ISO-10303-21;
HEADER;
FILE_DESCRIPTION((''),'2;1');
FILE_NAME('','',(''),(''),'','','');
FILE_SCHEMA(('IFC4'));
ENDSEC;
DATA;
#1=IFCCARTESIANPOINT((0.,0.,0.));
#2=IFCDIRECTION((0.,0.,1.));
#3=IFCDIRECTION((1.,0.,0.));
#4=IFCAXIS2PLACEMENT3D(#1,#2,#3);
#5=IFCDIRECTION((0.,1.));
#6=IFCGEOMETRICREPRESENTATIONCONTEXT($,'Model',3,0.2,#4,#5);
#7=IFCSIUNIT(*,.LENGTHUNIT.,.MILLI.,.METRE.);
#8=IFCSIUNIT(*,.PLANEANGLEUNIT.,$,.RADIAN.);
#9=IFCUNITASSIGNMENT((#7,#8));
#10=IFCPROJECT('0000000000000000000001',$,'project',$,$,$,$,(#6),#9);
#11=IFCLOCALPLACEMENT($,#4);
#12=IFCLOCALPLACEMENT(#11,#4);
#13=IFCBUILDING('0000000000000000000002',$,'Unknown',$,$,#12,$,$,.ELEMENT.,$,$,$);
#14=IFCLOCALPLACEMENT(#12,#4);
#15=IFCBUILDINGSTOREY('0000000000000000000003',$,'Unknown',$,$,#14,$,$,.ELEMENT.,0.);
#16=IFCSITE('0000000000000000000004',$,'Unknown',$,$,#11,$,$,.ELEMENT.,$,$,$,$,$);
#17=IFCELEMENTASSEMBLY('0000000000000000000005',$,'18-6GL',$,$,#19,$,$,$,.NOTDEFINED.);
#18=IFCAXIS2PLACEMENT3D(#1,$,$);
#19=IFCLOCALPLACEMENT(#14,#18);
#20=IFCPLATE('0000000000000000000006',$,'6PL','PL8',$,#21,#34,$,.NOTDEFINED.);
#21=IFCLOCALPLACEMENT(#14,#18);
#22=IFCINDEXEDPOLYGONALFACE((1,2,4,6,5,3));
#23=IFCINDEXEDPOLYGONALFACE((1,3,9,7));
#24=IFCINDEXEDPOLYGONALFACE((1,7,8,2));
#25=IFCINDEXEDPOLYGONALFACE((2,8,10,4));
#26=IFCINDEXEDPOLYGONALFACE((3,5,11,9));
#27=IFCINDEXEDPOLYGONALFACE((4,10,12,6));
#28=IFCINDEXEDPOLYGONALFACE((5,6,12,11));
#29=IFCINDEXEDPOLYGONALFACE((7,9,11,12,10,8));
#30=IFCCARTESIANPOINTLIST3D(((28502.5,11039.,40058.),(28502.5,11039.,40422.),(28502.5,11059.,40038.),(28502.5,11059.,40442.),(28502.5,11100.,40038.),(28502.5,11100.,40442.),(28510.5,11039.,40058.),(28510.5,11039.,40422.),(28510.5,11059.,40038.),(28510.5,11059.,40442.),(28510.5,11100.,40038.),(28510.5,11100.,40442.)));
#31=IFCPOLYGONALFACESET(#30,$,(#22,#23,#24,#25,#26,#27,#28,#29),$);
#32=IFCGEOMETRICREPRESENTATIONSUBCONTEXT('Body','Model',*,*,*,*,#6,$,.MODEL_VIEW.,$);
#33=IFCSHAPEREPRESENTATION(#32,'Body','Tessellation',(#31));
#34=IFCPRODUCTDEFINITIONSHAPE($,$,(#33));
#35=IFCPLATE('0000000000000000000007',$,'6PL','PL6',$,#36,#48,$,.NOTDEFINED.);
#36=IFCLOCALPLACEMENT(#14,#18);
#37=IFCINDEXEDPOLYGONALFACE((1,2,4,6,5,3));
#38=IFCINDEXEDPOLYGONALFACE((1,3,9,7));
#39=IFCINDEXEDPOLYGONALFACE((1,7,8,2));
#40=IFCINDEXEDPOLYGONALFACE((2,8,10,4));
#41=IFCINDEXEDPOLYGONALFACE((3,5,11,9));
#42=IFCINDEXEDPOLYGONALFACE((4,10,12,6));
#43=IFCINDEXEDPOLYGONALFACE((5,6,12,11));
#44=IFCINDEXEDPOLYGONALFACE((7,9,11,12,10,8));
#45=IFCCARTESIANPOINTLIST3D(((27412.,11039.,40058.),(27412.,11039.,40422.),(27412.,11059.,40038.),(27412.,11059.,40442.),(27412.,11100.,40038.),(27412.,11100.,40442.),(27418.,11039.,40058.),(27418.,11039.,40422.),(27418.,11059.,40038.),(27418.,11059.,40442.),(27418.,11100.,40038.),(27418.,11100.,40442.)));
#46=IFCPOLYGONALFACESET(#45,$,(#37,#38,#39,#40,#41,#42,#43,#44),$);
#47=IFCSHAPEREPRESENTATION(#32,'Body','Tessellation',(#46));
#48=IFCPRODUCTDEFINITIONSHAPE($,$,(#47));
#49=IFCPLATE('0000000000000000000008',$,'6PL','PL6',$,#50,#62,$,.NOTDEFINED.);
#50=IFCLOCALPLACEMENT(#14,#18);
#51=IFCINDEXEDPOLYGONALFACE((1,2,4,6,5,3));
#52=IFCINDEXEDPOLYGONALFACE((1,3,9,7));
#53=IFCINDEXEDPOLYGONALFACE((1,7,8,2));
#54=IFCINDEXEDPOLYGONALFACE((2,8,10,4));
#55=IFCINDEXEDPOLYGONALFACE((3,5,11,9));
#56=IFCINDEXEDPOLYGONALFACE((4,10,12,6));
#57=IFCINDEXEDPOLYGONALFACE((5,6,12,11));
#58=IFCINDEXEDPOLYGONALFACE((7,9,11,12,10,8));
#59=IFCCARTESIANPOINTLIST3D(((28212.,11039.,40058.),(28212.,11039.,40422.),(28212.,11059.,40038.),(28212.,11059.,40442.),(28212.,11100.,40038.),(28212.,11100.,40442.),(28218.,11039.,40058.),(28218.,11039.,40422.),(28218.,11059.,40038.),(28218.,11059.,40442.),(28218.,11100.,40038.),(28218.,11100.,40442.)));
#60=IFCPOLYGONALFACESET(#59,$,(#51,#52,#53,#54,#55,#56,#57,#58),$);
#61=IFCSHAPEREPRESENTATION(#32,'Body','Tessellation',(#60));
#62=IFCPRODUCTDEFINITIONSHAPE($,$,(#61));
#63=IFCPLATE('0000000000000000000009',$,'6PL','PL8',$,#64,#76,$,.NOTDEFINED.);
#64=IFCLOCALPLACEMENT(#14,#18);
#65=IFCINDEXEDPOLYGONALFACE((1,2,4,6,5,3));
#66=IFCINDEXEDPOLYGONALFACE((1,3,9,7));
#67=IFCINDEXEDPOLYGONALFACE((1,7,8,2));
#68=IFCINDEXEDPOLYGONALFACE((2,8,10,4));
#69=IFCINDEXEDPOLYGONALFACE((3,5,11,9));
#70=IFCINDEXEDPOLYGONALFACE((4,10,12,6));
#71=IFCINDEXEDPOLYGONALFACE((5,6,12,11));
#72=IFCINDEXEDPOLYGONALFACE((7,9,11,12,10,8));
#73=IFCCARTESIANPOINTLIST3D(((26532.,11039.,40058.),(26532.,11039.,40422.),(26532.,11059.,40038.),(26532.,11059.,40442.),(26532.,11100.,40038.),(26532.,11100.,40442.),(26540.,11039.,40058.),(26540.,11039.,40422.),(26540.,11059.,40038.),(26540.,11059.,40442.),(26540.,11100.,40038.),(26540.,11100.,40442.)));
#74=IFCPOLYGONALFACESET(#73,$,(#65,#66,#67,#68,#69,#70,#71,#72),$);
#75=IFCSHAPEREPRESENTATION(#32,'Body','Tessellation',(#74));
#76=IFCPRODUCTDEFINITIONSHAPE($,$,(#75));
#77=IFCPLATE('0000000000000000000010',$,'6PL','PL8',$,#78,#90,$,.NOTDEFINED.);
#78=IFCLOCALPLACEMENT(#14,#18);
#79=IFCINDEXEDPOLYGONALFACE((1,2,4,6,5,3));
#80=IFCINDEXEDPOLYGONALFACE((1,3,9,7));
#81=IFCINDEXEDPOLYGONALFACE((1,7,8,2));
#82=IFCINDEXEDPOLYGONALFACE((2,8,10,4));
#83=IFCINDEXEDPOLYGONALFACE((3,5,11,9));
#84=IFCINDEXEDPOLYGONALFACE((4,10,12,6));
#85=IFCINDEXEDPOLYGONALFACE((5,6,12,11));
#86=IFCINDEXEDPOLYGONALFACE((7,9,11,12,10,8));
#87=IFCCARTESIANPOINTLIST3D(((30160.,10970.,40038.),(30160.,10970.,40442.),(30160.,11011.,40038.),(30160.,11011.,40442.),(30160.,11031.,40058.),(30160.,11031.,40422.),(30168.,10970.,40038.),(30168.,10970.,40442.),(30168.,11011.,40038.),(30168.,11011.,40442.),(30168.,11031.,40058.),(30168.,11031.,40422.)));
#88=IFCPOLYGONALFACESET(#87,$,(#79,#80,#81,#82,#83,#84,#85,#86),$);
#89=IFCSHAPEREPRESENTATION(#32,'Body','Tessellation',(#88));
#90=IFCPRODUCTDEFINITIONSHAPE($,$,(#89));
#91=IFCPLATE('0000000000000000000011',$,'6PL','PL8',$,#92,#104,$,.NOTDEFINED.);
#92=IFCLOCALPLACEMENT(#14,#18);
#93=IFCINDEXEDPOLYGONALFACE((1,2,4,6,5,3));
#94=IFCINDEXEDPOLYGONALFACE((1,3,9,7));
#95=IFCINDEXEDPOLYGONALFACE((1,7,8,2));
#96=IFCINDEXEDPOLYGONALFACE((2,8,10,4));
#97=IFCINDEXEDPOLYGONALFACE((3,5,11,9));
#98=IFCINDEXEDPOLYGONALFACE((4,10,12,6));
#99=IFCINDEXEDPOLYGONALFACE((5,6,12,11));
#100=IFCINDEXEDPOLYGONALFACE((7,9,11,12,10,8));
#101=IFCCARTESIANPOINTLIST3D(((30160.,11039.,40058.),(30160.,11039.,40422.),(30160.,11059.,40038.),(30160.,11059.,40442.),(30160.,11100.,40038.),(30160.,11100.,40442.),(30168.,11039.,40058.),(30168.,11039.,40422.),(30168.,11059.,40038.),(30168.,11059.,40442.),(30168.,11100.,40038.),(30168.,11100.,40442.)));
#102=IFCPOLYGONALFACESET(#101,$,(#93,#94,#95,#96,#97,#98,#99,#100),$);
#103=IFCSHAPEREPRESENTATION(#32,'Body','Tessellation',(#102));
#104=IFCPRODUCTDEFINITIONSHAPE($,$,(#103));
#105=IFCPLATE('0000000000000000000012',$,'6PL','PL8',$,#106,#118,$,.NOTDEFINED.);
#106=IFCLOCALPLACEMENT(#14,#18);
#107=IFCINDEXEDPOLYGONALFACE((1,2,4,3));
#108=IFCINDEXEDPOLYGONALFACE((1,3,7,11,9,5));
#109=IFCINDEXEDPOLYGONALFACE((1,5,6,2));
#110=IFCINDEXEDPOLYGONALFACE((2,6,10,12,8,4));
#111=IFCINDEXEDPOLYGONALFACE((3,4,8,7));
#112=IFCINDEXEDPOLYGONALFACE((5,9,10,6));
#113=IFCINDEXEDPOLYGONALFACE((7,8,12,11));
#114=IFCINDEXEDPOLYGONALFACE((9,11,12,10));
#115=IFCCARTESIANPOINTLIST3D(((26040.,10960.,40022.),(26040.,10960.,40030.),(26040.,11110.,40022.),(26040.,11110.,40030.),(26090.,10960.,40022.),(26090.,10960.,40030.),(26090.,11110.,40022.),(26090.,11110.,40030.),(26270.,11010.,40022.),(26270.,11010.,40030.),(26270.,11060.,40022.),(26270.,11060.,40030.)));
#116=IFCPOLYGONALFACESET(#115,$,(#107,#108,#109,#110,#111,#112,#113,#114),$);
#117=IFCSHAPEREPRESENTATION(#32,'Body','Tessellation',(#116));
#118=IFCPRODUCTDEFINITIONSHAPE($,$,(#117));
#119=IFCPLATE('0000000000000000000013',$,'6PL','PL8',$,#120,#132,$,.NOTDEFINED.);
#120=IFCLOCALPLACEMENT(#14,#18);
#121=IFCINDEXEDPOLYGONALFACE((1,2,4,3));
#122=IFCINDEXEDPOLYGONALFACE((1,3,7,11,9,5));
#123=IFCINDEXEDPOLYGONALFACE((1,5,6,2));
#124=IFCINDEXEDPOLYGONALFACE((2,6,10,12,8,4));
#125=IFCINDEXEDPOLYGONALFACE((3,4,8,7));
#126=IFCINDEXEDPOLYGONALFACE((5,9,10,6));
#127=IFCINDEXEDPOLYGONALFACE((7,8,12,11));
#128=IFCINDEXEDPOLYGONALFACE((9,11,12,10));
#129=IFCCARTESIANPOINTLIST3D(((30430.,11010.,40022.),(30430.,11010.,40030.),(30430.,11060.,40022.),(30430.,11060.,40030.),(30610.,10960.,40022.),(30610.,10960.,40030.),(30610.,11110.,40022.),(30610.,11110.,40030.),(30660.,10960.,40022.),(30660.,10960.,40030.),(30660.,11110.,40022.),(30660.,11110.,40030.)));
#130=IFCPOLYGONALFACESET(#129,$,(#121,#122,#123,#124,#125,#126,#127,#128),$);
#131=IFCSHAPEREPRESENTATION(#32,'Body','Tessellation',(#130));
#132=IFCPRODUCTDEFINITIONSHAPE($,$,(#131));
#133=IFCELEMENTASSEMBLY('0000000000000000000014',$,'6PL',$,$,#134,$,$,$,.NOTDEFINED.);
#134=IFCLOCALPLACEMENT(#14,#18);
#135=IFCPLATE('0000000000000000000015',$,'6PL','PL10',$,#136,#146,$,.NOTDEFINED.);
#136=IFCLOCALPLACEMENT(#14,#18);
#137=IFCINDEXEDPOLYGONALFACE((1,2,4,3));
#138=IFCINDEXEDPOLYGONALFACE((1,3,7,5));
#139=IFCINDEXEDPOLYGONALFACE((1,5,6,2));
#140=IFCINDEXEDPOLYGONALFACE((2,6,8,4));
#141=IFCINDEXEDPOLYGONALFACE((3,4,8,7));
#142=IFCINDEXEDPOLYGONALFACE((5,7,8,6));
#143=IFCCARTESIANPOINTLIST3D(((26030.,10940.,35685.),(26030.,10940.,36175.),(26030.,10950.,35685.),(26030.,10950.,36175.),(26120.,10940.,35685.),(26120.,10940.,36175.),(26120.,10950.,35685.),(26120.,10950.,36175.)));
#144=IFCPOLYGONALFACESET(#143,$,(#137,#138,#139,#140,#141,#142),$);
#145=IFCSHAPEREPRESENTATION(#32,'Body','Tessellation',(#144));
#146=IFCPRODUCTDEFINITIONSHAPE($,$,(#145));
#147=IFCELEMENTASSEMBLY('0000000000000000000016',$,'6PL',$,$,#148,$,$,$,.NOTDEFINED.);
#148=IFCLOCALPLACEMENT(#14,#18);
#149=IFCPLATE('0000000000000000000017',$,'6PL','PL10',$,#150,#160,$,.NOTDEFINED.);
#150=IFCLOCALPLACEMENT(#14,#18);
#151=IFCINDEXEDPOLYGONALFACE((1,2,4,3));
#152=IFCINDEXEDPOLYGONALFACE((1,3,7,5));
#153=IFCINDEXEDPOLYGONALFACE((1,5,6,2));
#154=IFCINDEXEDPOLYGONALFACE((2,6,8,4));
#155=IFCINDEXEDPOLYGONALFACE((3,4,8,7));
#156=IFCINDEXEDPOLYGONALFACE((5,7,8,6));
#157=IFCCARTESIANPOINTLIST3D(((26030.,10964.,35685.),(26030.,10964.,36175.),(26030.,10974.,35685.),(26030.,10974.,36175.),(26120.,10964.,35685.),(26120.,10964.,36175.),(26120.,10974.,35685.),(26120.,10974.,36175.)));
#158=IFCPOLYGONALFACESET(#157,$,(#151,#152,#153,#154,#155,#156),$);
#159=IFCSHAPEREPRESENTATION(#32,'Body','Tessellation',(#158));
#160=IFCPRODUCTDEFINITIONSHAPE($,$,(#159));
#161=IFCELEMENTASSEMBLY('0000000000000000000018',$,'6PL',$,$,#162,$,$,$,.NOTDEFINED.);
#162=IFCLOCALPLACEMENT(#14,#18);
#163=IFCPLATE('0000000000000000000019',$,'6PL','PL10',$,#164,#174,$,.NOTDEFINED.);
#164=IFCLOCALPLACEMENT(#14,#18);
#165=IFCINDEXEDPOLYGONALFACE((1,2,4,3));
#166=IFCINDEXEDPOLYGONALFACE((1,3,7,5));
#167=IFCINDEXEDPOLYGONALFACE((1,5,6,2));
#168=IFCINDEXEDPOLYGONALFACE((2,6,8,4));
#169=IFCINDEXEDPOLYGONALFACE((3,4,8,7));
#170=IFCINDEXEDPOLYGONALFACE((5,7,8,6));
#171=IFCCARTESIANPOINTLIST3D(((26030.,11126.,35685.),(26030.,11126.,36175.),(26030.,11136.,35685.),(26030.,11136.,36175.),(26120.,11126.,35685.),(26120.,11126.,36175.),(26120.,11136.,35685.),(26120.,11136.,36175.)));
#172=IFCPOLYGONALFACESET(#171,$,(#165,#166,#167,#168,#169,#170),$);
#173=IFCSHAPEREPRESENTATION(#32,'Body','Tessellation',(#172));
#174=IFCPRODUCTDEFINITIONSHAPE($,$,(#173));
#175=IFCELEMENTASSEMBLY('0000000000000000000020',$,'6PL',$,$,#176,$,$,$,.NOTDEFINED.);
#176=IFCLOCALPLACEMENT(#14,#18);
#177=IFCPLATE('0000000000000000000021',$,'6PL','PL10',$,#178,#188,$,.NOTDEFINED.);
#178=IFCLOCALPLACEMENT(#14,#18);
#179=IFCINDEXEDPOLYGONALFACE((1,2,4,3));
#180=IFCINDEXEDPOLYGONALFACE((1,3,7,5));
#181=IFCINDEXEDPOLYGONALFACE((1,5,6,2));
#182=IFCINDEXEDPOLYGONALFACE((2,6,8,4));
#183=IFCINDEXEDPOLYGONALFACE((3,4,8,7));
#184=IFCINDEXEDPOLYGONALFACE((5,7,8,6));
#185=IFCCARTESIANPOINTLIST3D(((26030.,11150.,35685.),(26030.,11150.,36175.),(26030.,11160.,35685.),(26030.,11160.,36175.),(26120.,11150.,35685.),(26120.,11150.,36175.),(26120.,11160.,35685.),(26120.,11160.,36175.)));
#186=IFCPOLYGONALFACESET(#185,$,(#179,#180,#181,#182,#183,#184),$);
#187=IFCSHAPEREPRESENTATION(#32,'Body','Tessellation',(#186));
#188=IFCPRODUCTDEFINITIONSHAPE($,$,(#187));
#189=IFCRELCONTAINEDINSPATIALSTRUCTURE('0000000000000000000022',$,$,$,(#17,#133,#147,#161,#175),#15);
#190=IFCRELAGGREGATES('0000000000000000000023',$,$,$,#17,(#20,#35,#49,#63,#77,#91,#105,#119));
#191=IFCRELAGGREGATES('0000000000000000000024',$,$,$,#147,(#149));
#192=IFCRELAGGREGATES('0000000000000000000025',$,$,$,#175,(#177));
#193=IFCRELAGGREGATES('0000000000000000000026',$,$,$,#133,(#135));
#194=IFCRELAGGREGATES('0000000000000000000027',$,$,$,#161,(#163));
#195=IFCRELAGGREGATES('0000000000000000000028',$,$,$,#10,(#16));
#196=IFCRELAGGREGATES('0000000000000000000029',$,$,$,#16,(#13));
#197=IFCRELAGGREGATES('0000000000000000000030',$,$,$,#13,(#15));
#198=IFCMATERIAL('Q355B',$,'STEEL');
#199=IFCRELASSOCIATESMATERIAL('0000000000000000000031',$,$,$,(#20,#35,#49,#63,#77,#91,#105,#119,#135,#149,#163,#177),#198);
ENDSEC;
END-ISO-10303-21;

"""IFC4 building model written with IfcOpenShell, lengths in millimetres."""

from ifc_helpers import new_model, si_unit, direction, frame, origin_with_axes, place, context, subcontext, project, spatial, line, indexed_curve, outline, extrude, material, element, aggregate, save


model = new_model("IFC4")

# Units and contexts
model_context = context("Model", 3, precision=0.2, world=origin_with_axes(), true_north=direction((0.0, 1.0)))
body_context = subcontext(model_context, "Body", "Model", "MODEL_VIEW")
ifc_project = project(units=[si_unit("LENGTHUNIT", "METRE", prefix="MILLI"), si_unit("PLANEANGLEUNIT", "RADIAN")], contexts=[model_context])

# Site, building, storey
site_placement = place(None, origin_with_axes())
site = spatial("IfcSite", under=ifc_project, at=site_placement, Name="Unknown", CompositionType="ELEMENT")
building_placement = place(site_placement, origin_with_axes())
building = spatial("IfcBuilding", under=site, at=building_placement, Name="Unknown", CompositionType="ELEMENT")
storey_placement = place(building_placement, origin_with_axes())
storey = spatial("IfcBuildingStorey", under=building, at=storey_placement, Name="Unknown", CompositionType="ELEMENT", Elevation=0.0)

# Shared definitions
ifc_material_1 = material(Name="Q355B", Category="STEEL")

# Element assembly, plates
assembly_1_placement = place(storey_placement, frame((26000.0, 11035.0, 40240.0), z_axis=(0.0, -1.0, 0.0), x_axis=(1.0, 0.0, 0.0)))
assembly_1 = element("IfcElementAssembly", 1, at=assembly_1_placement, inside=storey, Name="18-6GL", PredefinedType="NOTDEFINED")
plate_1_placement = place(assembly_1_placement, frame((2506.5, -202.0, -4.0), z_axis=(1.0, 0.0, 0.0), x_axis=(0.0, 0.0, -1.0)))
plate_1 = element("IfcPlate", 2, at=plate_1_placement, material=ifc_material_1, Name="6PL", Description="PL8", PredefinedType="NOTDEFINED", context=body_context, shape_type="SolidModel", body=[
    extrude(outline(indexed_curve([(0.0, 20.0), (20.0, 0.0), (61.0, 0.0), (61.0, 404.0), (20.0, 404.0), (0.0, 384.0)], segments=[line(1, 2, 3, 4, 5, 6, 1)])), frame((0.0, 0.0, 4.0), z_axis=(0.0, 0.0, 1.0), x_axis=(1.0, 0.0, 0.0)), (0.0, 0.0, -1.0), 8.0),
])
plate_2_placement = place(assembly_1_placement, frame((1415.0, -202.0, -4.0), z_axis=(1.0, 0.0, 0.0), x_axis=(0.0, 0.0, -1.0)))
plate_2 = element("IfcPlate", 3, at=plate_2_placement, material=ifc_material_1, Name="6PL", Description="PL6", PredefinedType="NOTDEFINED", context=body_context, shape_type="SolidModel", body=[
    extrude(outline(indexed_curve([(0.0, 20.0), (20.0, 0.0), (61.0, 0.0), (61.0, 404.0), (20.0, 404.0), (0.0, 384.0)], segments=[line(1, 2, 3, 4, 5, 6, 1)])), frame((0.0, 0.0, 3.0), z_axis=(0.0, 0.0, 1.0), x_axis=(1.0, 0.0, 0.0)), (0.0, 0.0, -1.0), 6.0),
])
plate_3_placement = place(assembly_1_placement, frame((2215.0, -202.0, -4.0), z_axis=(1.0, 0.0, 0.0), x_axis=(0.0, 0.0, -1.0)))
plate_3 = element("IfcPlate", 4, at=plate_3_placement, material=ifc_material_1, Name="6PL", Description="PL6", PredefinedType="NOTDEFINED", context=body_context, shape_type="SolidModel", body=[
    extrude(outline(indexed_curve([(0.0, 20.0), (20.0, 0.0), (61.0, 0.0), (61.0, 404.0), (20.0, 404.0), (0.0, 384.0)], segments=[line(1, 2, 3, 4, 5, 6, 1)])), frame((0.0, 0.0, 3.0), z_axis=(0.0, 0.0, 1.0), x_axis=(1.0, 0.0, 0.0)), (0.0, 0.0, -1.0), 6.0),
])
plate_4_placement = place(assembly_1_placement, frame((536.0, -202.0, -4.0), z_axis=(1.0, 0.0, 0.0), x_axis=(0.0, 0.0, -1.0)))
plate_4 = element("IfcPlate", 5, at=plate_4_placement, material=ifc_material_1, Name="6PL", Description="PL8", PredefinedType="NOTDEFINED", context=body_context, shape_type="SolidModel", body=[
    extrude(outline(indexed_curve([(0.0, 20.0), (20.0, 0.0), (61.0, 0.0), (61.0, 404.0), (20.0, 404.0), (0.0, 384.0)], segments=[line(1, 2, 3, 4, 5, 6, 1)])), frame((0.0, 0.0, 4.0), z_axis=(0.0, 0.0, 1.0), x_axis=(1.0, 0.0, 0.0)), (0.0, 0.0, -1.0), 8.0),
])
plate_5_placement = place(assembly_1_placement, frame((4164.0, -202.0, 65.0), z_axis=(1.0, 0.0, 0.0), x_axis=(0.0, 0.0, -1.0)))
plate_5 = element("IfcPlate", 6, at=plate_5_placement, material=ifc_material_1, Name="6PL", Description="PL8", PredefinedType="NOTDEFINED", context=body_context, shape_type="SolidModel", body=[
    extrude(outline(indexed_curve([(0.0, 0.0), (41.0, 0.0), (61.0, 20.0), (61.0, 384.0), (41.0, 404.0), (0.0, 404.0)], segments=[line(1, 2, 3, 4, 5, 6, 1)])), frame((0.0, 0.0, 4.0), z_axis=(0.0, 0.0, 1.0), x_axis=(1.0, 0.0, 0.0)), (0.0, 0.0, -1.0), 8.0),
])
plate_6_placement = place(assembly_1_placement, frame((4164.0, -202.0, -4.0), z_axis=(1.0, 0.0, 0.0), x_axis=(0.0, 0.0, -1.0)))
plate_6 = element("IfcPlate", 7, at=plate_6_placement, material=ifc_material_1, Name="6PL", Description="PL8", PredefinedType="NOTDEFINED", context=body_context, shape_type="SolidModel", body=[
    extrude(outline(indexed_curve([(0.0, 20.0), (20.0, 0.0), (61.0, 0.0), (61.0, 404.0), (20.0, 404.0), (0.0, 384.0)], segments=[line(1, 2, 3, 4, 5, 6, 1)])), frame((0.0, 0.0, 4.0), z_axis=(0.0, 0.0, 1.0), x_axis=(1.0, 0.0, 0.0)), (0.0, 0.0, -1.0), 8.0),
])
plate_7_placement = place(assembly_1_placement, frame((90.0, -214.0, -75.0), z_axis=(0.0, 1.0, 0.0), x_axis=(-1.0, 0.0, 0.0)))
plate_7 = element("IfcPlate", 8, at=plate_7_placement, material=ifc_material_1, Name="6PL", Description="PL8", PredefinedType="NOTDEFINED", context=body_context, shape_type="SolidModel", body=[
    extrude(outline(indexed_curve([(0.0, 0.0), (50.0, 0.0), (50.0, 150.0), (0.0, 150.0), (-180.0, 100.0), (-180.0, 50.0)], segments=[line(1, 2, 3, 4, 5, 6, 1)])), frame((0.0, 0.0, 4.0), z_axis=(0.0, 0.0, 1.0), x_axis=(1.0, 0.0, 0.0)), (0.0, 0.0, -1.0), 8.0),
])
plate_8_placement = place(assembly_1_placement, frame((4610.0, -214.0, 75.0), z_axis=(0.0, 1.0, 0.0), x_axis=(1.0, 0.0, 0.0)))
plate_8 = element("IfcPlate", 9, at=plate_8_placement, material=ifc_material_1, Name="6PL", Description="PL8", PredefinedType="NOTDEFINED", context=body_context, shape_type="SolidModel", body=[
    extrude(outline(indexed_curve([(0.0, 0.0), (50.0, 0.0), (50.0, 150.0), (0.0, 150.0), (-180.0, 100.0), (-180.0, 50.0)], segments=[line(1, 2, 3, 4, 5, 6, 1)])), frame((0.0, 0.0, 4.0), z_axis=(0.0, 0.0, 1.0), x_axis=(1.0, 0.0, 0.0)), (0.0, 0.0, -1.0), 8.0),
])
aggregate(assembly_1, [plate_1, plate_2, plate_3, plate_4, plate_5, plate_6, plate_7, plate_8])

# Element assemblies, plates
assembly_2_placement = place(storey_placement, frame((26120.0, 10945.0, 36175.0), z_axis=(0.0, -1.0, 0.0), x_axis=(-1.0, 0.0, 0.0)))
assembly_2 = element("IfcElementAssembly", 10, at=assembly_2_placement, inside=storey, Name="6PL", PredefinedType="NOTDEFINED")
plate_9_placement = place(assembly_2_placement, origin_with_axes())
plate_9 = element("IfcPlate", 11, at=plate_9_placement, material=ifc_material_1, Name="6PL", Description="PL10", PredefinedType="NOTDEFINED", context=body_context, shape_type="SolidModel", body=[
    extrude(outline(indexed_curve([(0.0, 0.0), (90.0, 0.0), (90.0, 490.0), (0.0, 490.0)], segments=[line(1, 2, 3, 4, 1)])), frame((0.0, 0.0, 5.0), z_axis=(0.0, 0.0, 1.0), x_axis=(1.0, 0.0, 0.0)), (0.0, 0.0, -1.0), 10.0),
])
assembly_3_placement = place(storey_placement, frame((26120.0, 10969.0, 36175.0), z_axis=(0.0, -1.0, 0.0), x_axis=(-1.0, 0.0, 0.0)))
assembly_3 = element("IfcElementAssembly", 12, at=assembly_3_placement, inside=storey, Name="6PL", PredefinedType="NOTDEFINED")
plate_10_placement = place(assembly_3_placement, origin_with_axes())
plate_10 = element("IfcPlate", 13, at=plate_10_placement, material=ifc_material_1, Name="6PL", Description="PL10", PredefinedType="NOTDEFINED", context=body_context, shape_type="SolidModel", body=[
    extrude(outline(indexed_curve([(0.0, 0.0), (90.0, 0.0), (90.0, 490.0), (0.0, 490.0)], segments=[line(1, 2, 3, 4, 1)])), frame((0.0, 0.0, 5.0), z_axis=(0.0, 0.0, 1.0), x_axis=(1.0, 0.0, 0.0)), (0.0, 0.0, -1.0), 10.0),
])
aggregate(assembly_3, [plate_10])
assembly_4_placement = place(storey_placement, frame((26120.0, 11131.0, 36175.0), z_axis=(0.0, -1.0, 0.0), x_axis=(-1.0, 0.0, 0.0)))
assembly_4 = element("IfcElementAssembly", 14, at=assembly_4_placement, inside=storey, Name="6PL", PredefinedType="NOTDEFINED")
plate_11_placement = place(assembly_4_placement, origin_with_axes())
plate_11 = element("IfcPlate", 15, at=plate_11_placement, material=ifc_material_1, Name="6PL", Description="PL10", PredefinedType="NOTDEFINED", context=body_context, shape_type="SolidModel", body=[
    extrude(outline(indexed_curve([(0.0, 0.0), (90.0, 0.0), (90.0, 490.0), (0.0, 490.0)], segments=[line(1, 2, 3, 4, 1)])), frame((0.0, 0.0, 5.0), z_axis=(0.0, 0.0, 1.0), x_axis=(1.0, 0.0, 0.0)), (0.0, 0.0, -1.0), 10.0),
])
assembly_5_placement = place(storey_placement, frame((26120.0, 11155.0, 36175.0), z_axis=(0.0, -1.0, 0.0), x_axis=(-1.0, 0.0, 0.0)))
assembly_5 = element("IfcElementAssembly", 16, at=assembly_5_placement, inside=storey, Name="6PL", PredefinedType="NOTDEFINED")
plate_12_placement = place(assembly_5_placement, origin_with_axes())
plate_12 = element("IfcPlate", 17, at=plate_12_placement, material=ifc_material_1, Name="6PL", Description="PL10", PredefinedType="NOTDEFINED", context=body_context, shape_type="SolidModel", body=[
    extrude(outline(indexed_curve([(0.0, 0.0), (90.0, 0.0), (90.0, 490.0), (0.0, 490.0)], segments=[line(1, 2, 3, 4, 1)])), frame((0.0, 0.0, 5.0), z_axis=(0.0, 0.0, 1.0), x_axis=(1.0, 0.0, 0.0)), (0.0, 0.0, -1.0), 10.0),
])
aggregate(assembly_5, [plate_12])

aggregate(assembly_2, [plate_9])
aggregate(assembly_4, [plate_11])

save(model, "model.ifc")
